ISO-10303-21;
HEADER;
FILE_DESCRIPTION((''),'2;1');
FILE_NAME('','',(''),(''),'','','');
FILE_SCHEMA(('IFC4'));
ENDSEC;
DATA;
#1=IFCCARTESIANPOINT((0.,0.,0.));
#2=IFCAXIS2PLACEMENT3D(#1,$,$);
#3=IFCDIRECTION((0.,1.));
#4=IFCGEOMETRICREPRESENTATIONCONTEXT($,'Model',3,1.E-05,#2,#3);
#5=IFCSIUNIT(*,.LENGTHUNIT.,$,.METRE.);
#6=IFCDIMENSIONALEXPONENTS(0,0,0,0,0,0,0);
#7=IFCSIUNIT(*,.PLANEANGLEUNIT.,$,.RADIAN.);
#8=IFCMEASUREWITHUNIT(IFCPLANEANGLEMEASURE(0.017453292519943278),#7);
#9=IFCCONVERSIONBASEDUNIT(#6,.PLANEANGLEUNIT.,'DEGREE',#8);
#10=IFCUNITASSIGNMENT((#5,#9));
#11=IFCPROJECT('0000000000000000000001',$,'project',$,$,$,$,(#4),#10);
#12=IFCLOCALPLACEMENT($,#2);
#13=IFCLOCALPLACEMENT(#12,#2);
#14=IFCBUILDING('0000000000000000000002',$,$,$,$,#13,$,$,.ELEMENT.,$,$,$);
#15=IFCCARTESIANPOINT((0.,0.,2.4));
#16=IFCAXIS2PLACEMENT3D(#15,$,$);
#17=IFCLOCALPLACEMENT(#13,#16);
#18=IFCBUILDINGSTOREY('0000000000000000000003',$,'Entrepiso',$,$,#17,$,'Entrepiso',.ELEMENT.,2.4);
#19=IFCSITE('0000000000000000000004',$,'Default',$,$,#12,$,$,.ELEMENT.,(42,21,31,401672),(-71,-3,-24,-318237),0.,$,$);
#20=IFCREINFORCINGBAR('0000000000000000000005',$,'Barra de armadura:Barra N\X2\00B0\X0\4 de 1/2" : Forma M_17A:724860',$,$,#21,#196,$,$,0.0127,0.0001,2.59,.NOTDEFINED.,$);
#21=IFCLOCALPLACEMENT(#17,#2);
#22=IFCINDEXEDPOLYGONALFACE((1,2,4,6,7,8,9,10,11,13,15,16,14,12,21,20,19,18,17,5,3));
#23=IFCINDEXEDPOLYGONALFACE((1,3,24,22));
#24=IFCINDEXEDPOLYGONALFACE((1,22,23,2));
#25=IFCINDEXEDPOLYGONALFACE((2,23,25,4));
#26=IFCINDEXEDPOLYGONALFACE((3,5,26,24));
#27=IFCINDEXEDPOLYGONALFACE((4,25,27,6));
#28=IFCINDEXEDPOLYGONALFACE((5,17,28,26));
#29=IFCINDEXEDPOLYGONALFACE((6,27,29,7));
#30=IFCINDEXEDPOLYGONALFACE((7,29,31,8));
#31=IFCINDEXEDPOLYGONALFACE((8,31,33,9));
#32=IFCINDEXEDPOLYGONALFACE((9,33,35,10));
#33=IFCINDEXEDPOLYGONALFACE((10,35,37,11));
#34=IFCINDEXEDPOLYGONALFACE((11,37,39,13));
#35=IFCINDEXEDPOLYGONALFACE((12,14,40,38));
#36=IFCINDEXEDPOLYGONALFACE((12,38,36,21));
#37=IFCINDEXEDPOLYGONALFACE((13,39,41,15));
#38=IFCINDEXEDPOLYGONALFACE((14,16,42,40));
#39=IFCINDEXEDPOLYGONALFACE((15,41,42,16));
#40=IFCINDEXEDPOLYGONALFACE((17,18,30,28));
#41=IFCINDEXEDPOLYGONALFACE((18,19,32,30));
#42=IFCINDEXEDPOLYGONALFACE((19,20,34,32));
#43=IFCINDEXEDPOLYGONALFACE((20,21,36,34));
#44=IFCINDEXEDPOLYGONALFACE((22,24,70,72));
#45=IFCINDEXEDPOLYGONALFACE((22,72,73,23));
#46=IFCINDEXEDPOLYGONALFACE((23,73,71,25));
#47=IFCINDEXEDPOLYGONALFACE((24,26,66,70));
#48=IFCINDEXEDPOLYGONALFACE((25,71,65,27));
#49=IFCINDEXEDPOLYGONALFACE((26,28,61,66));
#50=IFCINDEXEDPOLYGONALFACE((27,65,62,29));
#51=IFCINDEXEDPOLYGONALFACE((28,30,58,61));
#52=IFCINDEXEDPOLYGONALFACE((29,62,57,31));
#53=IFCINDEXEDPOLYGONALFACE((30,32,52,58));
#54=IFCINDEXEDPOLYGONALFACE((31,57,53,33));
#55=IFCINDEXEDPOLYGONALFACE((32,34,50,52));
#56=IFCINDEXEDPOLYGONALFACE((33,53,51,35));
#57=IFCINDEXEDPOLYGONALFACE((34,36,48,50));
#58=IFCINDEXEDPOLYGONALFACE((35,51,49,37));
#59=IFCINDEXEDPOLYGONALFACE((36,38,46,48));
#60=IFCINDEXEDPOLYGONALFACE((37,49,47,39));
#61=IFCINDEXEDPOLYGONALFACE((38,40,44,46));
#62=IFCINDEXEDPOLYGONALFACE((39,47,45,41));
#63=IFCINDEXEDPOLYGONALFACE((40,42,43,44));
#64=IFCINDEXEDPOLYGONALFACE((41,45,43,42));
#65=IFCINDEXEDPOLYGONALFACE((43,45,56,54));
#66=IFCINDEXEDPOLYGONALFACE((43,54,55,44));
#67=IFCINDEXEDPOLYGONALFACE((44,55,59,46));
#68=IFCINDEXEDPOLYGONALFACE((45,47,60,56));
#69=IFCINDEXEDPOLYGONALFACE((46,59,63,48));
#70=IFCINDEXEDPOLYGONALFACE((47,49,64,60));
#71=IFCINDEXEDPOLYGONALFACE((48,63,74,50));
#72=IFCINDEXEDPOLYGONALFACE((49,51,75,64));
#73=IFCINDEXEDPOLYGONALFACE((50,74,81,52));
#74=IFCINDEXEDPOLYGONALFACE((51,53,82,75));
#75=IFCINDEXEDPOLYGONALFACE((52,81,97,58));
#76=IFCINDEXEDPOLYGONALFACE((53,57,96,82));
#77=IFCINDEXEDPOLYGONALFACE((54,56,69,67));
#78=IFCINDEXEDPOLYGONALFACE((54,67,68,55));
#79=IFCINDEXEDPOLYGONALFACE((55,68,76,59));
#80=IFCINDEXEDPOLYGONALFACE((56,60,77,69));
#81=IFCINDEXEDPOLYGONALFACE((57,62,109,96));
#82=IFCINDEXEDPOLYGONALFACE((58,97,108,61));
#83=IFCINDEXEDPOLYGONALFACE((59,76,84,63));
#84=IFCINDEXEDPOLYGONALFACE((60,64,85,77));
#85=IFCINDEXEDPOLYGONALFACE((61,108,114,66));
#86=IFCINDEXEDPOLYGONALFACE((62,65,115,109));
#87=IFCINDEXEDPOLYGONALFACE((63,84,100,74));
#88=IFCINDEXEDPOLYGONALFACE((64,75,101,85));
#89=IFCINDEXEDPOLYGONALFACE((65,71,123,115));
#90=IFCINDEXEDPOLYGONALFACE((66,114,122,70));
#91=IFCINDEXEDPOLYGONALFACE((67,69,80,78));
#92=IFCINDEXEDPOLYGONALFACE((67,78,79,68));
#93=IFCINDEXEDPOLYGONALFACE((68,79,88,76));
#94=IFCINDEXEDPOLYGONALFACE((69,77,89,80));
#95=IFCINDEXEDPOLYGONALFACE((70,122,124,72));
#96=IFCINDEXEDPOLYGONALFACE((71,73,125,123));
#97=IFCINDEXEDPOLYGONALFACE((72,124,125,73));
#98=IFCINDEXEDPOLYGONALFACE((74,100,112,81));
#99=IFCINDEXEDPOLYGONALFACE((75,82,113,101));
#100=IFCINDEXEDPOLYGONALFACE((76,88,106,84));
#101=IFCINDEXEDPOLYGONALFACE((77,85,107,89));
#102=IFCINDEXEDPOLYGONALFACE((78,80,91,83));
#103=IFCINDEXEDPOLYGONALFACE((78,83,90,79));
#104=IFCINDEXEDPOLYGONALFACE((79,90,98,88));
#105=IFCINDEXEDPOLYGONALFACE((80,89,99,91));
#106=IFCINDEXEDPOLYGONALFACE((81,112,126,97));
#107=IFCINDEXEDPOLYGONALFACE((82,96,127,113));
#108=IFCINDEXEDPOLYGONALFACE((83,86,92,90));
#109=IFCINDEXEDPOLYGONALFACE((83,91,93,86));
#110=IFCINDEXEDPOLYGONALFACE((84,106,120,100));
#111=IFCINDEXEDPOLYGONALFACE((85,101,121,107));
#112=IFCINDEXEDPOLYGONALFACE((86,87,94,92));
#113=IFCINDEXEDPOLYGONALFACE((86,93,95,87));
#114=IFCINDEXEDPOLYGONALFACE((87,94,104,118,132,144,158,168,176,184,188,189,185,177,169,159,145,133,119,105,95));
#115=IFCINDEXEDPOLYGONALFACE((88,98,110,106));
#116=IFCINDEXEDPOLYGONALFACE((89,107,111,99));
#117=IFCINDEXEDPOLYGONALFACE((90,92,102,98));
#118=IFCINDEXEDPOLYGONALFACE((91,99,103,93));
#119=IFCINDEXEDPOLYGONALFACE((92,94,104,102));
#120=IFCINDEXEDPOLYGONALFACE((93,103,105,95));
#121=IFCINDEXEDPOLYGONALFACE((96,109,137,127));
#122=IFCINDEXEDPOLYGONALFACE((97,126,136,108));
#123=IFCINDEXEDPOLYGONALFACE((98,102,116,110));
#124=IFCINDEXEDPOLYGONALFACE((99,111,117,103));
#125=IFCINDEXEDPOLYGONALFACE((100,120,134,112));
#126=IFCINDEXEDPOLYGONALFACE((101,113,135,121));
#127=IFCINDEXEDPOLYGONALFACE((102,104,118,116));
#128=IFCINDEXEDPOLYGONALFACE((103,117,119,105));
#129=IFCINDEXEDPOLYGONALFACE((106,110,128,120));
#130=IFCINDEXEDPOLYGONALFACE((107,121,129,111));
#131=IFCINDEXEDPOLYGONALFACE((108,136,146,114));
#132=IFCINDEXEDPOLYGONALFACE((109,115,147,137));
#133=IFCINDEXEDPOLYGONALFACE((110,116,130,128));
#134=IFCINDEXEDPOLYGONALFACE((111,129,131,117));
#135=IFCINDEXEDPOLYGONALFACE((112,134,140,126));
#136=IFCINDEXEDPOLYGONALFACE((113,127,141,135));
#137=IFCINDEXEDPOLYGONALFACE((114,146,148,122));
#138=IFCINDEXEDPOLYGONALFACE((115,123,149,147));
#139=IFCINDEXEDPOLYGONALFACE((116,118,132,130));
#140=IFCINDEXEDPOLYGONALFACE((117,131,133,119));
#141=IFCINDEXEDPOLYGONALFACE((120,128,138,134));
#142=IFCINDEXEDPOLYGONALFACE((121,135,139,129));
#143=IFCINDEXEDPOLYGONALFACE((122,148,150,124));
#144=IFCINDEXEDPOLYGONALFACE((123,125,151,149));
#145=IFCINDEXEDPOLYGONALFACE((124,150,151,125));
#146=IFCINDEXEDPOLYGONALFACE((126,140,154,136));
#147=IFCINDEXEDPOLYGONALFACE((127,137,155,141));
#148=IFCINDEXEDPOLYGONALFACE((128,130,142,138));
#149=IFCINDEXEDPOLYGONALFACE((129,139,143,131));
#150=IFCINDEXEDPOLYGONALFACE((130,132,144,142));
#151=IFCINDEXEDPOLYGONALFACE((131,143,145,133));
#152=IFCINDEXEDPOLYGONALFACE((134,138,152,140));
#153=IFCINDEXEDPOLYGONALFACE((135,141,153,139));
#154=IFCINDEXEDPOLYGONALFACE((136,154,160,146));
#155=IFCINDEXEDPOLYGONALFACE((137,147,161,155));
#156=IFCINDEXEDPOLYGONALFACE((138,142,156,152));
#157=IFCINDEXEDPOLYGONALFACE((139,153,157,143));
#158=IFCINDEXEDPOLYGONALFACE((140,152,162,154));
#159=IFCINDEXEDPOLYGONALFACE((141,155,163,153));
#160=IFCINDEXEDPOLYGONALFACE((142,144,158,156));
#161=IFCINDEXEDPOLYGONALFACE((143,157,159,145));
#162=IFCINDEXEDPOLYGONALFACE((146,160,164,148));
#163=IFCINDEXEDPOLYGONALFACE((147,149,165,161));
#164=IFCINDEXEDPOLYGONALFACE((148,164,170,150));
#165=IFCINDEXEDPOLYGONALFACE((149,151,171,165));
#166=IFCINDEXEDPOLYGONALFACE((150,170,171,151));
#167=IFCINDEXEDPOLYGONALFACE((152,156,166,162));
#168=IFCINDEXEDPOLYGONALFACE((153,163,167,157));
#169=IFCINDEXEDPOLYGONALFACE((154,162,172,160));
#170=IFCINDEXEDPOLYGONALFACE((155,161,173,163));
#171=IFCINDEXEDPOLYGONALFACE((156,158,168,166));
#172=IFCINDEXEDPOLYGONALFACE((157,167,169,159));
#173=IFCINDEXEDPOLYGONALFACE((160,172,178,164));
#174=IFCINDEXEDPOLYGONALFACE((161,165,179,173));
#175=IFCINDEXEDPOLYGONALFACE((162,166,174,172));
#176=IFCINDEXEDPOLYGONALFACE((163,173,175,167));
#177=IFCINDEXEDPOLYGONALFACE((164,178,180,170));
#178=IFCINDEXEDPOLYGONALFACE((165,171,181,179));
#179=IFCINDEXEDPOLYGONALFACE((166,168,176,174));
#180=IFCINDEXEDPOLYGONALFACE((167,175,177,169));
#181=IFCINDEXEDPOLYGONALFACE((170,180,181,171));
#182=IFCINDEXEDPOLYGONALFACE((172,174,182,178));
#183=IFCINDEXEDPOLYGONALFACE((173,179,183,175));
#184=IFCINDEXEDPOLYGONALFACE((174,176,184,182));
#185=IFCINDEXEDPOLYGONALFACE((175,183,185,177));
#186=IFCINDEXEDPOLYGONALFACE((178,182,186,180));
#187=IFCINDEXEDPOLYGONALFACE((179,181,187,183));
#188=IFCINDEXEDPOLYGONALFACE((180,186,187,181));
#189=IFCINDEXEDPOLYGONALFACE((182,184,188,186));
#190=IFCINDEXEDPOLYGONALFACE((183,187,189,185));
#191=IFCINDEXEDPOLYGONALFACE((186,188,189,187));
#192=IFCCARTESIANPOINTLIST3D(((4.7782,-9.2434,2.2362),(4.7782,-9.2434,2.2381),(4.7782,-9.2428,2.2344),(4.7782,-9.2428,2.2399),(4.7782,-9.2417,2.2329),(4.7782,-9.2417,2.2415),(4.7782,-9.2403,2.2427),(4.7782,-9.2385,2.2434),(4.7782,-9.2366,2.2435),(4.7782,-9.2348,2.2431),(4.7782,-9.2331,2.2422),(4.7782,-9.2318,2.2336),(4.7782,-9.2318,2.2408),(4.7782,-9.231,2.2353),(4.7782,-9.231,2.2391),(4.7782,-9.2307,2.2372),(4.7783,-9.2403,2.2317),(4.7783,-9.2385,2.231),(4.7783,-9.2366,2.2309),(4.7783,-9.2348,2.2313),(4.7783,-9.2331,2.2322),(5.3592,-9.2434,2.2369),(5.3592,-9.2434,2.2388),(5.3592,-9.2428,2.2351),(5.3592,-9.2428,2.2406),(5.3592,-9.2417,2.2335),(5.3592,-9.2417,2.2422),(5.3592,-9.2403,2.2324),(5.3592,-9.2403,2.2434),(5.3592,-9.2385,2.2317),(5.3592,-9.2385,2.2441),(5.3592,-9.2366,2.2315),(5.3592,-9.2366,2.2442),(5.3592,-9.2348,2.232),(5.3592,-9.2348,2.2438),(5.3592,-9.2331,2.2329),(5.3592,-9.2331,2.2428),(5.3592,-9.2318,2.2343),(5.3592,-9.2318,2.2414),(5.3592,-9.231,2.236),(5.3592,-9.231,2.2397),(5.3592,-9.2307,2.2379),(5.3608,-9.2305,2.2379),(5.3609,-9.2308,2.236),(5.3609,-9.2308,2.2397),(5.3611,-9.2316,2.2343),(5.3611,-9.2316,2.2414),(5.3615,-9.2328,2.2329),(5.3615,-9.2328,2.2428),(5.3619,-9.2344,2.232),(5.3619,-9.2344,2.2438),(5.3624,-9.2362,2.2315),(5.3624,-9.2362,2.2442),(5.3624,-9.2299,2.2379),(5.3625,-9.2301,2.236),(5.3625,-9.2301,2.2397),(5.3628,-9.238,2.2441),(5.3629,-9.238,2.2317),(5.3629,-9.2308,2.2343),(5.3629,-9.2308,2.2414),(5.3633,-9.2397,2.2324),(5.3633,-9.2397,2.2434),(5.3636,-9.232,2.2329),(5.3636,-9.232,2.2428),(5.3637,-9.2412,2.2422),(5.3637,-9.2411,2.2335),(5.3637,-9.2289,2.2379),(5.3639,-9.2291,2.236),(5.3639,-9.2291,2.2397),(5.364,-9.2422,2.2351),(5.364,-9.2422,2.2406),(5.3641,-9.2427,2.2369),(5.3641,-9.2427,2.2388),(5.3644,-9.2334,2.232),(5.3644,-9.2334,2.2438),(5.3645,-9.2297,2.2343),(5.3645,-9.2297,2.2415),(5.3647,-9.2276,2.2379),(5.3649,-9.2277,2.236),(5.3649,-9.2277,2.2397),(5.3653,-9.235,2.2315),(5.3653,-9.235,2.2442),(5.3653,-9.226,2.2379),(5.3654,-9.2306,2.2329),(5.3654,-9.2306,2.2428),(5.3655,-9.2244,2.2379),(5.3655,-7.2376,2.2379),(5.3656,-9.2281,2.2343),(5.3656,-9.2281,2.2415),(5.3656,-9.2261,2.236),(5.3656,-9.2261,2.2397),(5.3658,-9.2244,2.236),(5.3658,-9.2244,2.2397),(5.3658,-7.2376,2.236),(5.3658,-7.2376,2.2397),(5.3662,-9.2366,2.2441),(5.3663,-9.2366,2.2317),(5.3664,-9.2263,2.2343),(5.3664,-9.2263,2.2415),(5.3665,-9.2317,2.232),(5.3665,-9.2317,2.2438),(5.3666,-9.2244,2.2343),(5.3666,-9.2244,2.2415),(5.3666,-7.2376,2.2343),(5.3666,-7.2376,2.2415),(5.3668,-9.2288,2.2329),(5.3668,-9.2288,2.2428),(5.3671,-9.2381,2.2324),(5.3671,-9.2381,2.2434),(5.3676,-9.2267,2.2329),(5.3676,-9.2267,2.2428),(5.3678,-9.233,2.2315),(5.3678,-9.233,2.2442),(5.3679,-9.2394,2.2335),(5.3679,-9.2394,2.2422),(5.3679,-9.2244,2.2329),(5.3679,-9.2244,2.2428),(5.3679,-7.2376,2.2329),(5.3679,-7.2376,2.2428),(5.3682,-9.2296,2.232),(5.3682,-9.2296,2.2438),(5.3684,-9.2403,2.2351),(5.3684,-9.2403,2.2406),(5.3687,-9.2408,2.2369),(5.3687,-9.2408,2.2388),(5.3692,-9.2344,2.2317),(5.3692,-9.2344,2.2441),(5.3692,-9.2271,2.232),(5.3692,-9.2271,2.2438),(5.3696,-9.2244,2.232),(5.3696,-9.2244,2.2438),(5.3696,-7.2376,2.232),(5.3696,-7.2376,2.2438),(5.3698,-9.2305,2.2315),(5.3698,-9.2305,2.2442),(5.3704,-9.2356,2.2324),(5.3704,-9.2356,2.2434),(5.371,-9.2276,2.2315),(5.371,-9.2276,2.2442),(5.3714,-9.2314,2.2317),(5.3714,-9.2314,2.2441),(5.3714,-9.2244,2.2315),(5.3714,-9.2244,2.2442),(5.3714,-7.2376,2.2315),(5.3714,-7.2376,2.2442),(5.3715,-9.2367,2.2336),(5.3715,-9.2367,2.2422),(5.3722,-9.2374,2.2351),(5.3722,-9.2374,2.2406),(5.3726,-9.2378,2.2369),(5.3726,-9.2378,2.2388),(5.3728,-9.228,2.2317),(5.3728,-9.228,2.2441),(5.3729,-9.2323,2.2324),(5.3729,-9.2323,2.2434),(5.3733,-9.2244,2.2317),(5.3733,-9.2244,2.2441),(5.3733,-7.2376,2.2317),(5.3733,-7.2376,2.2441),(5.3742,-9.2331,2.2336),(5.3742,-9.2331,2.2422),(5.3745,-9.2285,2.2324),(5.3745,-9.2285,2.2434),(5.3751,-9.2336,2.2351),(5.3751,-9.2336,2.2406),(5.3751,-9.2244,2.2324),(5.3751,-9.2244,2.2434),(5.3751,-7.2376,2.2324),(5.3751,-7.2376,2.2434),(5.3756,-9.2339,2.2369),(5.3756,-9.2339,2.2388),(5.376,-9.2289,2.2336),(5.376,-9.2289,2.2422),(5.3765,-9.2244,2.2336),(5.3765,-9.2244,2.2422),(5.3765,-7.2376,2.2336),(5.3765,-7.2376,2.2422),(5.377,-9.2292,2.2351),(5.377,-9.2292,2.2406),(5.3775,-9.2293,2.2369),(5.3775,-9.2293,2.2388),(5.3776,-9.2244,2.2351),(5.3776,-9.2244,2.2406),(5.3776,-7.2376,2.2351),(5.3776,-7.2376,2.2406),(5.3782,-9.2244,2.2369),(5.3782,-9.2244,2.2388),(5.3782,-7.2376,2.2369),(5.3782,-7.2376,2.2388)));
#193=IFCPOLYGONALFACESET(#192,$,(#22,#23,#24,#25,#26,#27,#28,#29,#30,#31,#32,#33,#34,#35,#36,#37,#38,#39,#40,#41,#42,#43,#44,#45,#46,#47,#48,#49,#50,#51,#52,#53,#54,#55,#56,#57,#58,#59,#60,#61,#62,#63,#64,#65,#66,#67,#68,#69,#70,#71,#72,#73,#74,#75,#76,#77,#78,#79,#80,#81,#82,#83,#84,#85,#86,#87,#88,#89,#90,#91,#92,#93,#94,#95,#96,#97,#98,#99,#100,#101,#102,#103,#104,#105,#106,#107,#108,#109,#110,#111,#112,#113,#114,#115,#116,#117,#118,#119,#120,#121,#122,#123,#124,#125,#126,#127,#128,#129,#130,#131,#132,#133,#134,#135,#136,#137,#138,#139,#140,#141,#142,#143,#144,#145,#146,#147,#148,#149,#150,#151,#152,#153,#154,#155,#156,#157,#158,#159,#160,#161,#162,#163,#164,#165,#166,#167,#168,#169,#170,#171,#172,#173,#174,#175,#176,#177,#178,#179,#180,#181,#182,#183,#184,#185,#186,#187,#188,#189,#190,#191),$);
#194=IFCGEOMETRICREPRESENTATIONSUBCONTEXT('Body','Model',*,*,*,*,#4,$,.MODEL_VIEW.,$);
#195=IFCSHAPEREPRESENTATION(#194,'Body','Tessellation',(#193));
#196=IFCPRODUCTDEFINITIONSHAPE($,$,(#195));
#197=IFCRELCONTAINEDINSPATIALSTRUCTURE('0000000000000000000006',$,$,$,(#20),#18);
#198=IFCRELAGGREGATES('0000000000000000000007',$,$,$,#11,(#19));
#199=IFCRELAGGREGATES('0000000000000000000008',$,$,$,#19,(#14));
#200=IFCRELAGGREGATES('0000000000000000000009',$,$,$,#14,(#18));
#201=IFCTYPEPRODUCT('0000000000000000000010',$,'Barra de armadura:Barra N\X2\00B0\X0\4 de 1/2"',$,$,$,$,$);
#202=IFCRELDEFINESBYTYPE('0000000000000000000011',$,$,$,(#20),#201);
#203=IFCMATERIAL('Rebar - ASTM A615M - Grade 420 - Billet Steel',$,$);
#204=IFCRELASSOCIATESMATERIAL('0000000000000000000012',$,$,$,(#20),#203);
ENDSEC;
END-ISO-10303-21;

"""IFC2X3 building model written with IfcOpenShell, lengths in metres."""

from ifc_helpers import new_model, entity, si_unit, converted_unit, direction, frame, origin, place, context, subcontext, project, spatial, material, type_object, element, save


model = new_model("IFC2X3")

# Units and contexts
model_context = context("Model", 3, precision=1e-05, world=origin(), true_north=direction((0.0, 1.0)))
body_context = subcontext(model_context, "Body", "Model", "MODEL_VIEW")
ifc_project = project(units=[si_unit("LENGTHUNIT", "METRE"), converted_unit("PLANEANGLEUNIT", "DEGREE", entity("IfcPlaneAngleMeasure", 0.017453292519943278), si_unit("PLANEANGLEUNIT", "RADIAN"), dimensions=[0, 0, 0, 0, 0, 0, 0])], contexts=[model_context])

# Site, building, storey
site_placement = place(None, origin())
site = spatial("IfcSite", under=ifc_project, at=site_placement, Name="Default", CompositionType="ELEMENT", RefLatitude=(42, 21, 31, 401672), RefLongitude=(-71, -3, -24, -318237), RefElevation=0.0)
building_placement = place(site_placement, origin())
building = spatial("IfcBuilding", under=site, at=building_placement, CompositionType="ELEMENT")
storey_placement = place(building_placement, frame((0.0, 0.0, 2.4)))
storey = spatial("IfcBuildingStorey", under=building, at=storey_placement, Name="Entrepiso", LongName="Entrepiso", CompositionType="ELEMENT", Elevation=2.4)

# Reinforcing bar
ifc_material = material(Name="Rebar - ASTM A615M - Grade 420 - Billet Steel")
type_product_1 = type_object("IfcTypeProduct", Name="Barra de armadura:Barra N°4 de 1/2\"")
reinforcing_bar_1_placement = place(storey_placement, origin())
element("IfcReinforcingBar", 1, at=reinforcing_bar_1_placement, inside=storey, type_object=type_product_1, material=ifc_material, Name="Barra de armadura:Barra N°4 de 1/2\" : Forma M_17A:724860", BarLength=2.59, BarRole="NOTDEFINED", CrossSectionArea=0.0001, NominalDiameter=0.0127, context=body_context, shape_type="AdvancedSweptSolid", body=[
    entity("IfcSweptDiskSolid", entity("IfcCompositeCurve", [entity("IfcCompositeCurveSegment", "CONTINUOUS", True, entity("IfcPolyline", [entity("IfcCartesianPoint", [5.3719, -7.2376, 2.2379]), entity("IfcCartesianPoint", [5.3719, -9.2244, 2.2379])])), entity("IfcCompositeCurveSegment", "CONTINUOUS", True, entity("IfcTrimmedCurve", entity("IfcCircle", entity("IfcAxis2Placement3D", entity("IfcCartesianPoint", [5.3592, -9.2244, 2.2379]), entity("IfcDirection", [0.001144, 0.0, -0.999999]), entity("IfcDirection", [0.0, -1.0, 0.0])), 0.0127), [entity("IfcParameterValue", 270.0)], [entity("IfcParameterValue", 360.0)], True, "PARAMETER")), entity("IfcCompositeCurveSegment", "CONTINUOUS", True, entity("IfcPolyline", [entity("IfcCartesianPoint", [5.3592, -9.2371, 2.2379]), entity("IfcCartesianPoint", [4.7782, -9.2371, 2.2372])]))], False), 0.0063, None, 0.0, 92.0),
])

save(model, "model.ifc")
